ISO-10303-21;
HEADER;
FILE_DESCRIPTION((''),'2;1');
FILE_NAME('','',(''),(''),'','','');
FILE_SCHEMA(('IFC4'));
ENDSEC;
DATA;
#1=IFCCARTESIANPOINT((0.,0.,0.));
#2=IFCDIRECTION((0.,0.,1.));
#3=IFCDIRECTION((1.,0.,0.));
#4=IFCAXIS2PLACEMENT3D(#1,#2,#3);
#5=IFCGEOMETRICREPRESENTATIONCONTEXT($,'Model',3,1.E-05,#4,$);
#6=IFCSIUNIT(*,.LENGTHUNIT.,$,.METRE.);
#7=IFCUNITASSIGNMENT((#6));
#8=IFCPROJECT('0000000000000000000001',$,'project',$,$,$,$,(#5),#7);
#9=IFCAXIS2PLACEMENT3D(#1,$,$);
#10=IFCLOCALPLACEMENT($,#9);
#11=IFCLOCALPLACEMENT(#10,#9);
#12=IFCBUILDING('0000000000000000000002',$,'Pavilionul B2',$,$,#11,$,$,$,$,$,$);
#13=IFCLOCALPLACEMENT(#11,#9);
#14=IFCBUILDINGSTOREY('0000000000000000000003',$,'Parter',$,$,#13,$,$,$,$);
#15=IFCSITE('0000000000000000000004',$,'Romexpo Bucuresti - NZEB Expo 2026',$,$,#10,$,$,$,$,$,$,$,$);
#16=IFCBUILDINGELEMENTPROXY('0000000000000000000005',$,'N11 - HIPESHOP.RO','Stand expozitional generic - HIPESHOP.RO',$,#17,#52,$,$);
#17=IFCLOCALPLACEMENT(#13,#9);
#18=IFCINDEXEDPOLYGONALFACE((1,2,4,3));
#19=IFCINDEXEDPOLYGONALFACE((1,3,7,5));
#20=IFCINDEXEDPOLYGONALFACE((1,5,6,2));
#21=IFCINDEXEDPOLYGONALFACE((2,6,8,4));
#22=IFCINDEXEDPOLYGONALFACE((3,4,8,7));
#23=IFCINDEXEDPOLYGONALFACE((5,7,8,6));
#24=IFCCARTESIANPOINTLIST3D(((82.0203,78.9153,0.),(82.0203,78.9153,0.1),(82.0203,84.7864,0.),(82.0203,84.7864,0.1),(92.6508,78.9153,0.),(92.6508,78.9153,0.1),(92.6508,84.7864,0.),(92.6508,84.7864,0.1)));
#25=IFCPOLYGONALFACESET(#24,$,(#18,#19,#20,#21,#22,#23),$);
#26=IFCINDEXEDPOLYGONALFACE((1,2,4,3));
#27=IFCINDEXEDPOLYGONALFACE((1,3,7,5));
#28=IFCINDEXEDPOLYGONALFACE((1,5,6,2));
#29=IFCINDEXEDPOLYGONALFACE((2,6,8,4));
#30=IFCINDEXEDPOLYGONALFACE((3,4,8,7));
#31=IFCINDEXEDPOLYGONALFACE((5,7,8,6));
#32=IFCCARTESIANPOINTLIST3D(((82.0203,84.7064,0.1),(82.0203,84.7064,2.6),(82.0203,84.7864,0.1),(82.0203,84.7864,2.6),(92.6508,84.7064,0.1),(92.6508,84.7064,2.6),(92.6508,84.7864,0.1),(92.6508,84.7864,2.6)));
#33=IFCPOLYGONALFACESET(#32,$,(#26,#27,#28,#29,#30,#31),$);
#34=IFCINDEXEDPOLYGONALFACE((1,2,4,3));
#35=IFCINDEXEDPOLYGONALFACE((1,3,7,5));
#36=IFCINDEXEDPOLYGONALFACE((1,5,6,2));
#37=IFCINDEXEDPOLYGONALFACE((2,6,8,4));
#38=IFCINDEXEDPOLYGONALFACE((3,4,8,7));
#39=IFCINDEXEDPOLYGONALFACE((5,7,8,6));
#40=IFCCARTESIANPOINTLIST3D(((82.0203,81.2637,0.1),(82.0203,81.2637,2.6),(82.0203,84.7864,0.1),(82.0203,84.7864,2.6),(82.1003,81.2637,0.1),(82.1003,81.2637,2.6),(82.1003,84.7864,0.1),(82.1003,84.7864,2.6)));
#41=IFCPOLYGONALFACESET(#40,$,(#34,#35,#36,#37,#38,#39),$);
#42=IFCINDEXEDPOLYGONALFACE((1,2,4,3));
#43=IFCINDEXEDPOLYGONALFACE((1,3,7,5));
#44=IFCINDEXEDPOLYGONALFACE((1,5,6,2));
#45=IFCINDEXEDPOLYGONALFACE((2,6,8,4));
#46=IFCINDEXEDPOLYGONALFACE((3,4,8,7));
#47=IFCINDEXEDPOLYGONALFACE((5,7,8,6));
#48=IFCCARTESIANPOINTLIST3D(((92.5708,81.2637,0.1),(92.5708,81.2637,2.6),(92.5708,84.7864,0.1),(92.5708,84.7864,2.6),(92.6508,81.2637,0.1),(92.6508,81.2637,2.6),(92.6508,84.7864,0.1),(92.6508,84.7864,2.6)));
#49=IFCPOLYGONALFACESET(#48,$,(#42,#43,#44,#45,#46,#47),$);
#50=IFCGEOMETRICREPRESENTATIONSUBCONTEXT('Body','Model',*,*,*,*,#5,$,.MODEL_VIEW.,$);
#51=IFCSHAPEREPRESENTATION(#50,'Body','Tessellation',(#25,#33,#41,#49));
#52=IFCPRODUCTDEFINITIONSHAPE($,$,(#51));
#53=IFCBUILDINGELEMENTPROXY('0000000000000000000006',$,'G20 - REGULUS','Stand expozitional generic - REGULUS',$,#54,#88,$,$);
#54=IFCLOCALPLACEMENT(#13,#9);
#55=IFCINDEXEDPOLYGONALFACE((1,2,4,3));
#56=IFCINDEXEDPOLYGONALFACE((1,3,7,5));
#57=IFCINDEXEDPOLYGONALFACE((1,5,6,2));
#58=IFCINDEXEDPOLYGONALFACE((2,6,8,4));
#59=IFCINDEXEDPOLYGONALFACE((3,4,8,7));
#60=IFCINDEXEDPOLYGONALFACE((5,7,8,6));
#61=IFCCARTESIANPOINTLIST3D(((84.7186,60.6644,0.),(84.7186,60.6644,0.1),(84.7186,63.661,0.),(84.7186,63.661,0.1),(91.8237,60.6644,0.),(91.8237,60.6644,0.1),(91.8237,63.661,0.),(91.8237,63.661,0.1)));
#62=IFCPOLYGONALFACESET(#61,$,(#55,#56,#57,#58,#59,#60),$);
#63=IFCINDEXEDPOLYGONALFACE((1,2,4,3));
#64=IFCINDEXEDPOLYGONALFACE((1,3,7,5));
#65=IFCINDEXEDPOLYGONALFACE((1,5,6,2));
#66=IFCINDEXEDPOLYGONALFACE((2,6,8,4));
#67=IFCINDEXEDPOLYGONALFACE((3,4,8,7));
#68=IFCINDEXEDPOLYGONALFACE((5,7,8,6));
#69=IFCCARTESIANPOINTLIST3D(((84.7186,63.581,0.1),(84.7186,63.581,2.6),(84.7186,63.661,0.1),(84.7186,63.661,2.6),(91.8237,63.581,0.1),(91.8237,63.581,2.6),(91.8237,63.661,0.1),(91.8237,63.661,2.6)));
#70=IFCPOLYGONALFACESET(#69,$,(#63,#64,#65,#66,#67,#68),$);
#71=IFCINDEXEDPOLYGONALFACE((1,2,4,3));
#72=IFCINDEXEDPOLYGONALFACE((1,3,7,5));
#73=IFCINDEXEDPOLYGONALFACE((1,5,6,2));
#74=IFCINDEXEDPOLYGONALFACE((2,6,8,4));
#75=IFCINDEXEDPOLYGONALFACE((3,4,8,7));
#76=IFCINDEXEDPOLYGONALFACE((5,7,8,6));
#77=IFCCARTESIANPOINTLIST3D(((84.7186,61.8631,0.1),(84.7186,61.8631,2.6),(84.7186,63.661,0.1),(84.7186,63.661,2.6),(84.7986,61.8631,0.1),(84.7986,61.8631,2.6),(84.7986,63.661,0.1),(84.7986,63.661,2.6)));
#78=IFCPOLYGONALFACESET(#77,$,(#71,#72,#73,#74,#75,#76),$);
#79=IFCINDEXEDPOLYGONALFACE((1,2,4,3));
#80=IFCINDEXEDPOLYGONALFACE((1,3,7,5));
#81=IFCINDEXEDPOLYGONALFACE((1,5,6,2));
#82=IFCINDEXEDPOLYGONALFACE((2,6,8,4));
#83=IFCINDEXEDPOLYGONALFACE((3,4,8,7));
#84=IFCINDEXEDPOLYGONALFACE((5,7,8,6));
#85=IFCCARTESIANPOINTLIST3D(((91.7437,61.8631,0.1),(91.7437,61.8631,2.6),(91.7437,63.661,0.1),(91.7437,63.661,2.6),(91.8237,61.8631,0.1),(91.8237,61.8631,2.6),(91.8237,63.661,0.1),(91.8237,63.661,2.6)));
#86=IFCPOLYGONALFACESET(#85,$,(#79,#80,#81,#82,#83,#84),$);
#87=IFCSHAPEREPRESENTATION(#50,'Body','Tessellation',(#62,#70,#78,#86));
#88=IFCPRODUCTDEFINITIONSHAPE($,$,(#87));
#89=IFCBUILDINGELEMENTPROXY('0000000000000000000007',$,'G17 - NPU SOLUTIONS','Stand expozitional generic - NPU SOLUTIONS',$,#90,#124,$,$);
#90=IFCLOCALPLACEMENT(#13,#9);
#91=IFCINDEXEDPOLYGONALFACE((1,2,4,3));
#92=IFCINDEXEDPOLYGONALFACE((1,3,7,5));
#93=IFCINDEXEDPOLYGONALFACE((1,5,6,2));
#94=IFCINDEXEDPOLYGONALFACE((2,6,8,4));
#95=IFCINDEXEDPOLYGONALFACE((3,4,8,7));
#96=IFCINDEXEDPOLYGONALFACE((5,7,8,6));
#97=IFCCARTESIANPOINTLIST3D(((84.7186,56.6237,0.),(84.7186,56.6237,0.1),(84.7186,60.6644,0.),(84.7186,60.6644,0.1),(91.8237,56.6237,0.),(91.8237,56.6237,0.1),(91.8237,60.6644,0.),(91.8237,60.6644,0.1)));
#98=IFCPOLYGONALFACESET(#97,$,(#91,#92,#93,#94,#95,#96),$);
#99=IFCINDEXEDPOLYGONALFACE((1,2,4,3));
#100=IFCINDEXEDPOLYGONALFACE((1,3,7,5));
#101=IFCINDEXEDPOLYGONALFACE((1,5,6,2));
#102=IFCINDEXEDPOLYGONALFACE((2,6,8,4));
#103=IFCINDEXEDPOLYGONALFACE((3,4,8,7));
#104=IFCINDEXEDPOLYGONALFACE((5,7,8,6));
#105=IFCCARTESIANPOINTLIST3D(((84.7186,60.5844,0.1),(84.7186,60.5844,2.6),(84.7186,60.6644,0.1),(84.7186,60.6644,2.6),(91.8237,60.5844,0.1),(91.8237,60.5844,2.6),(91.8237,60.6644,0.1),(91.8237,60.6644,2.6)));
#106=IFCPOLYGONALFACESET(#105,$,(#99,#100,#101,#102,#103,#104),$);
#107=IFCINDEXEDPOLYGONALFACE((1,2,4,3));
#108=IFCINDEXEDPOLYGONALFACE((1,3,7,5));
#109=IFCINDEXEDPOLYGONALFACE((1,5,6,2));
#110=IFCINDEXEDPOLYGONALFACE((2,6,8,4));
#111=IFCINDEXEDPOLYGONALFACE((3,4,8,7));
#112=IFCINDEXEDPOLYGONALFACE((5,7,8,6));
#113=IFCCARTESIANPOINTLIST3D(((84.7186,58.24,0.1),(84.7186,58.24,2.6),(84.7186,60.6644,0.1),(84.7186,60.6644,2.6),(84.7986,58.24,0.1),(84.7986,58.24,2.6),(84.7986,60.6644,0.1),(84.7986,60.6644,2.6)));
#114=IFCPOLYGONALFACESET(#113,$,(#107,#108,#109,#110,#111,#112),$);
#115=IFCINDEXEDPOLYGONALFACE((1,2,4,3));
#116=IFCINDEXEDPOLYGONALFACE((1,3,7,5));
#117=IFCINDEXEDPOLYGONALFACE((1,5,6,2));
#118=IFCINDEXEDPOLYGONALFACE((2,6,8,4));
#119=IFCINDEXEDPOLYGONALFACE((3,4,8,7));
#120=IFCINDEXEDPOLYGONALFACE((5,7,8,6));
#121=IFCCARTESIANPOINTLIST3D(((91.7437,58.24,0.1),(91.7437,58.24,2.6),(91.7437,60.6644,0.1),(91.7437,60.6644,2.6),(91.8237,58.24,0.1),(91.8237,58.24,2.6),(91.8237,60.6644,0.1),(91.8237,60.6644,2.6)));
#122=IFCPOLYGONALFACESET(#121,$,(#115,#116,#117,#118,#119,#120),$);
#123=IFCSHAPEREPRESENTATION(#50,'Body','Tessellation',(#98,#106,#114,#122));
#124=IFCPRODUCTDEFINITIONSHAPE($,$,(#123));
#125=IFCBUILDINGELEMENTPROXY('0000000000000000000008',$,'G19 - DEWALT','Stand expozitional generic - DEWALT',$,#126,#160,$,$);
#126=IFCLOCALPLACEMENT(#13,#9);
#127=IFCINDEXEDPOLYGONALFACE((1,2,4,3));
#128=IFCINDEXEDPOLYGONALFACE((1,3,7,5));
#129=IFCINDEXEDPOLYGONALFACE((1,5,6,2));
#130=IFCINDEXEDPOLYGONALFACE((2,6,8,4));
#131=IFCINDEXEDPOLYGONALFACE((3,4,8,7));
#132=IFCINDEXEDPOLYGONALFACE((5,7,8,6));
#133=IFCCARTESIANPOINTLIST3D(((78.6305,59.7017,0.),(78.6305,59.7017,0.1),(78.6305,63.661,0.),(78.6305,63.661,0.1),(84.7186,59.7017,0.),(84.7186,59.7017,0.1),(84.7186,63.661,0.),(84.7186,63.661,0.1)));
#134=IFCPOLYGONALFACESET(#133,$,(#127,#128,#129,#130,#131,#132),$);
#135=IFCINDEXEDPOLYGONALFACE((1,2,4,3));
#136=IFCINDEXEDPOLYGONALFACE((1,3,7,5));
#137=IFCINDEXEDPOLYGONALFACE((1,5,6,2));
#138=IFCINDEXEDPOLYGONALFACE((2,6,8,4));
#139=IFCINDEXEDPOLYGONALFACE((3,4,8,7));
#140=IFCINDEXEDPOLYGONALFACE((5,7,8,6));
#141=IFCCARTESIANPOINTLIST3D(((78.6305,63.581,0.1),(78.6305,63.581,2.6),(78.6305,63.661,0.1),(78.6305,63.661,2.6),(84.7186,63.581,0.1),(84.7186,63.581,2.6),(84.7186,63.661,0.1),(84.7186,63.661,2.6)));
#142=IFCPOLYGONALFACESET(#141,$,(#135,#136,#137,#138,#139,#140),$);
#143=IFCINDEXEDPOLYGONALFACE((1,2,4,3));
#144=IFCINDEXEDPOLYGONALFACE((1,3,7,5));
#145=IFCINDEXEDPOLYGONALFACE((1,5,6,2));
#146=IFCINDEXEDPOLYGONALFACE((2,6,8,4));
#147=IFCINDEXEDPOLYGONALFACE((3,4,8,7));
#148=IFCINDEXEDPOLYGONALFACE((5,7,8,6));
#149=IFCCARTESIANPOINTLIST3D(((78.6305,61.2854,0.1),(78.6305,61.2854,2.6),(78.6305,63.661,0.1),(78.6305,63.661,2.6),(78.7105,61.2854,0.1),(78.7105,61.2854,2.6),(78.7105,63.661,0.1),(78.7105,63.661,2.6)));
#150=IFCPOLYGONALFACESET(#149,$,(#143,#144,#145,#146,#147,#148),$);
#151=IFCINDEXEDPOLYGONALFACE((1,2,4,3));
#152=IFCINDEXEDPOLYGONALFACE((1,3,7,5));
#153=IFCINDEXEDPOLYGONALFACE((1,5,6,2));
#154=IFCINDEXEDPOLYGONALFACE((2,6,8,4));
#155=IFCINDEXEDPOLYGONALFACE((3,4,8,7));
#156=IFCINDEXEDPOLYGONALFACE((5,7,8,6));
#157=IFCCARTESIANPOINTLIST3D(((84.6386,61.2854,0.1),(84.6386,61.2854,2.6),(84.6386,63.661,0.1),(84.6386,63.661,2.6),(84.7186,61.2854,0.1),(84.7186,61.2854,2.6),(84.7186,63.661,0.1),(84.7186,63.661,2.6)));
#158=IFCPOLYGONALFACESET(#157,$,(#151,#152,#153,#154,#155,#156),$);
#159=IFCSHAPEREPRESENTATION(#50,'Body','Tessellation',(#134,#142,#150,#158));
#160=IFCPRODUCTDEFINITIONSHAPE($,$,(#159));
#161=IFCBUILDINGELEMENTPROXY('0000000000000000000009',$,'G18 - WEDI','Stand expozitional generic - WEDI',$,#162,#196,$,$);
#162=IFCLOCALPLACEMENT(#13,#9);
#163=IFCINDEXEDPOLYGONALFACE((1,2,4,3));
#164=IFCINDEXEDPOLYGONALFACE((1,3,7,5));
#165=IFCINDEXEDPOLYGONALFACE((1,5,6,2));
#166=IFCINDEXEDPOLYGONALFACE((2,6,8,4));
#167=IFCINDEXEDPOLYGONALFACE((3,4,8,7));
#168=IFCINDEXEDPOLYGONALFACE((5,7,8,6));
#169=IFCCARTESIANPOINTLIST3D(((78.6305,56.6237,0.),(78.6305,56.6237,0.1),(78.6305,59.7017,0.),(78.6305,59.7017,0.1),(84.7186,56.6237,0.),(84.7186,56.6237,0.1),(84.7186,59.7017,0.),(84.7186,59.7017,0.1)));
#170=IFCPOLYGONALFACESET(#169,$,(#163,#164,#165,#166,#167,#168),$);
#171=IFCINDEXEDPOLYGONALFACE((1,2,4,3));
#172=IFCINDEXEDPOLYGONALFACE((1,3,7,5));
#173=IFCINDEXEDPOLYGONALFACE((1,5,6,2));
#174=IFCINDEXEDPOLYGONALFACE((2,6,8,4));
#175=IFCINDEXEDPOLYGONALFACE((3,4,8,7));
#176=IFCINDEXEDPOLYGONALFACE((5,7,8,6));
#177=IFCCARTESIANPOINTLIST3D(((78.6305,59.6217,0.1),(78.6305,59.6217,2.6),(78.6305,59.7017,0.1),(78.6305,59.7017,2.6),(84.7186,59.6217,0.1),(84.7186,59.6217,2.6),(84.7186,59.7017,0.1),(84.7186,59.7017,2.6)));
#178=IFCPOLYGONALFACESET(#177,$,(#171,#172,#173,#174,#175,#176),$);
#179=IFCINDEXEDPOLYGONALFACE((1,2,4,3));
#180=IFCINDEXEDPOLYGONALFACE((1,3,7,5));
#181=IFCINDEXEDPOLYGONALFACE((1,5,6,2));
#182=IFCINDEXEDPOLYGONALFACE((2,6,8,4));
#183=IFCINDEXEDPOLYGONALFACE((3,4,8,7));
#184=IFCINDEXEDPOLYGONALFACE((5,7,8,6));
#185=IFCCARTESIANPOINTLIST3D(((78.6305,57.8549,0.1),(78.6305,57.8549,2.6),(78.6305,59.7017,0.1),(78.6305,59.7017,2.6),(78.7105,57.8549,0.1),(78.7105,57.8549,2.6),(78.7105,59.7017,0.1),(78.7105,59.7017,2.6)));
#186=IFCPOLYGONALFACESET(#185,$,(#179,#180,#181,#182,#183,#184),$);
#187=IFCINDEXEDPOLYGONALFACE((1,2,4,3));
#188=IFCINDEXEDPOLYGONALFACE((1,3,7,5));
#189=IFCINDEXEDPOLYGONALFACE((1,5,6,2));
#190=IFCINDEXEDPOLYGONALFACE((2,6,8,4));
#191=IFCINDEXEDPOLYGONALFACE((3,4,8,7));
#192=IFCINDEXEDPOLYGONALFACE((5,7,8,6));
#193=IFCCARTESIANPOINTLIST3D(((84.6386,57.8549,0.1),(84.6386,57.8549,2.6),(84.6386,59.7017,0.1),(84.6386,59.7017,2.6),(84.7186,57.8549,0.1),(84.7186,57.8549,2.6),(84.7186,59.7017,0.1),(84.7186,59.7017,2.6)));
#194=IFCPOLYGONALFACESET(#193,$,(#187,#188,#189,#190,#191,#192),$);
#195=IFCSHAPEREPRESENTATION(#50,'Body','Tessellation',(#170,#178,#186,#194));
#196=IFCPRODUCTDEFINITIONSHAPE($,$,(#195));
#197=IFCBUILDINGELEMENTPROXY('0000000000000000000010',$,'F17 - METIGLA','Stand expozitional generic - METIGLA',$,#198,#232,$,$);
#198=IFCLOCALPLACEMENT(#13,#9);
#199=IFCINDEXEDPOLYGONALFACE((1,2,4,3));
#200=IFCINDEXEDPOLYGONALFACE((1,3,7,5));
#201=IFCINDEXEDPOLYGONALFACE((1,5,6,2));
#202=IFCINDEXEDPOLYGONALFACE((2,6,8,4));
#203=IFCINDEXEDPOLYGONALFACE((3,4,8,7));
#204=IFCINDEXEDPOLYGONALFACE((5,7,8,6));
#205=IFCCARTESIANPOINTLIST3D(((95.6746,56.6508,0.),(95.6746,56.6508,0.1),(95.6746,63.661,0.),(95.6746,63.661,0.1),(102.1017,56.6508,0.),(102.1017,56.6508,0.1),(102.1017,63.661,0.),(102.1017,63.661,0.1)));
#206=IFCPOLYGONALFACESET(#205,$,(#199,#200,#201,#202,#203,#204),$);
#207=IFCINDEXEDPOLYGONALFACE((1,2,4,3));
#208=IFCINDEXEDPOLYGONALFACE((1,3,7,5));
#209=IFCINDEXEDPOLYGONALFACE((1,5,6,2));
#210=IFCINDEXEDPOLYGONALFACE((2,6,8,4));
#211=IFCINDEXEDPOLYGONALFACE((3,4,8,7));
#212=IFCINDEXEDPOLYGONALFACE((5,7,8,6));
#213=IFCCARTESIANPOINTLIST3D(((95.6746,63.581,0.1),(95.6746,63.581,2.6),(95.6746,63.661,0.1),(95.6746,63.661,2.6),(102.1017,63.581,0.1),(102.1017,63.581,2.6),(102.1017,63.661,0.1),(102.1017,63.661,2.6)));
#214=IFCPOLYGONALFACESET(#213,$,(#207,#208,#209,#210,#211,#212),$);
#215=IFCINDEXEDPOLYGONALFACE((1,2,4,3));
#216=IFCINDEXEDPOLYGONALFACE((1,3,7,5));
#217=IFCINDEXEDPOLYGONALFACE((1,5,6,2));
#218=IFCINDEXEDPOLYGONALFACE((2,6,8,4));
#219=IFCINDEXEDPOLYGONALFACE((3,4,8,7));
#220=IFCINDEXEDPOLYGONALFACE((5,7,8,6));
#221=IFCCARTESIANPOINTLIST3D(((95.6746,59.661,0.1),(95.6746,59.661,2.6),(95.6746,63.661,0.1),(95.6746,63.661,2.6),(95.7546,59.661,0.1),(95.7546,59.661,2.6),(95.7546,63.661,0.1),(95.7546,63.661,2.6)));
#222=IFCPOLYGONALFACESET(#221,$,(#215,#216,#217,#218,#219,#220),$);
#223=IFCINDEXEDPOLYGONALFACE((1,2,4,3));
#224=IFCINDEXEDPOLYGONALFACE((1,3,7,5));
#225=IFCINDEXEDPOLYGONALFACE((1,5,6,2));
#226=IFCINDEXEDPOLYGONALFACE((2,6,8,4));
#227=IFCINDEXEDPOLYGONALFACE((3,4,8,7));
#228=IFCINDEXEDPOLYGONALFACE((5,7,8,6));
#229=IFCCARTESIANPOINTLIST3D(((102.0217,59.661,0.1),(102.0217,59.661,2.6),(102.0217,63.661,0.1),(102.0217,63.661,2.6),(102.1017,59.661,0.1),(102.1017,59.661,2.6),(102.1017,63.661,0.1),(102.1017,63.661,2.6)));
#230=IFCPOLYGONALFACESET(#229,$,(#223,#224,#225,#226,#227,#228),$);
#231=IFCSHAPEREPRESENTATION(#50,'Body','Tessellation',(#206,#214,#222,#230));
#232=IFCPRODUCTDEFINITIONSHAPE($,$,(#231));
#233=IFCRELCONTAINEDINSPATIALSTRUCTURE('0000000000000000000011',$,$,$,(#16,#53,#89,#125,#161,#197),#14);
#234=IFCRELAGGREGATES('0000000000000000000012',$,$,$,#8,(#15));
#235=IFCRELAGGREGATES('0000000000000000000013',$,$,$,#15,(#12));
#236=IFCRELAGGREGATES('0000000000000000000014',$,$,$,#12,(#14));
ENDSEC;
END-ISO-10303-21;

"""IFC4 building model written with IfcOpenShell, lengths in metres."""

from ifc_helpers import new_model, si_unit, frame, frame_2d, origin, origin_with_axes, place, context, subcontext, project, spatial, rectangle, extrude, element, save


model = new_model("IFC4")

# Units and contexts
model_context = context("Model", 3, precision=1e-05, world=origin_with_axes())
body_context = subcontext(model_context, "Body", "Model", "MODEL_VIEW")
ifc_project = project(units=[si_unit("LENGTHUNIT", "METRE")], contexts=[model_context])

# Site, building, storey
site_placement = place(None, origin())
site = spatial("IfcSite", under=ifc_project, at=site_placement, Name="Romexpo Bucuresti - NZEB Expo 2026")
building_placement = place(site_placement, origin())
building = spatial("IfcBuilding", under=site, at=building_placement, Name="Pavilionul B2")
storey_placement = place(building_placement, origin())
storey = spatial("IfcBuildingStorey", under=building, at=storey_placement, Name="Parter")

# Building element proxies
proxy_1_placement = place(storey_placement, frame((82.0203, 78.9153, 0.0), z_axis=(0.0, 0.0, 1.0), x_axis=(1.0, 0.0, 0.0)))
element("IfcBuildingElementProxy", 1, at=proxy_1_placement, inside=storey, Name="N11 - HIPESHOP.RO", Description="Stand expozitional generic - HIPESHOP.RO", context=body_context, shape_type="SweptSolid", body=[
    extrude(rectangle(XDim=10.6305, YDim=5.8712, at=frame_2d((5.3153, 2.9356))), origin(), (0.0, 0.0, 1.0), 0.1),
    extrude(rectangle(XDim=10.6305, YDim=0.08, at=frame_2d((5.3153, 5.8312))), frame((0.0, 0.0, 0.1)), (0.0, 0.0, 1.0), 2.5),
    extrude(rectangle(XDim=0.08, YDim=3.5227, at=frame_2d((0.04, 4.1098))), frame((0.0, 0.0, 0.1)), (0.0, 0.0, 1.0), 2.5),
    extrude(rectangle(XDim=0.08, YDim=3.5227, at=frame_2d((10.5905, 4.1098))), frame((0.0, 0.0, 0.1)), (0.0, 0.0, 1.0), 2.5),
])
proxy_2_placement = place(storey_placement, frame((84.7186, 60.6644, 0.0), z_axis=(0.0, 0.0, 1.0), x_axis=(1.0, 0.0, 0.0)))
element("IfcBuildingElementProxy", 2, at=proxy_2_placement, inside=storey, Name="G20 - REGULUS", Description="Stand expozitional generic - REGULUS", context=body_context, shape_type="SweptSolid", body=[
    extrude(rectangle(XDim=7.1051, YDim=2.9966, at=frame_2d((3.5525, 1.4983))), origin(), (0.0, 0.0, 1.0), 0.1),
    extrude(rectangle(XDim=7.1051, YDim=0.08, at=frame_2d((3.5525, 2.9566))), frame((0.0, 0.0, 0.1)), (0.0, 0.0, 1.0), 2.5),
    extrude(rectangle(XDim=0.08, YDim=1.798, at=frame_2d((0.04, 2.0976))), frame((0.0, 0.0, 0.1)), (0.0, 0.0, 1.0), 2.5),
    extrude(rectangle(XDim=0.08, YDim=1.798, at=frame_2d((7.0651, 2.0976))), frame((0.0, 0.0, 0.1)), (0.0, 0.0, 1.0), 2.5),
])
proxy_3_placement = place(storey_placement, frame((84.7186, 56.6237, 0.0), z_axis=(0.0, 0.0, 1.0), x_axis=(1.0, 0.0, 0.0)))
element("IfcBuildingElementProxy", 3, at=proxy_3_placement, inside=storey, Name="G17 - NPU SOLUTIONS", Description="Stand expozitional generic - NPU SOLUTIONS", context=body_context, shape_type="SweptSolid", body=[
    extrude(rectangle(XDim=7.1051, YDim=4.0407, at=frame_2d((3.5525, 2.0203))), origin(), (0.0, 0.0, 1.0), 0.1),
    extrude(rectangle(XDim=7.1051, YDim=0.08, at=frame_2d((3.5525, 4.0007))), frame((0.0, 0.0, 0.1)), (0.0, 0.0, 1.0), 2.5),
    extrude(rectangle(XDim=0.08, YDim=2.4244, at=frame_2d((0.04, 2.8285))), frame((0.0, 0.0, 0.1)), (0.0, 0.0, 1.0), 2.5),
    extrude(rectangle(XDim=0.08, YDim=2.4244, at=frame_2d((7.0651, 2.8285))), frame((0.0, 0.0, 0.1)), (0.0, 0.0, 1.0), 2.5),
])
proxy_4_placement = place(storey_placement, frame((78.6305, 59.7017, 0.0), z_axis=(0.0, 0.0, 1.0), x_axis=(1.0, 0.0, 0.0)))
element("IfcBuildingElementProxy", 4, at=proxy_4_placement, inside=storey, Name="G19 - DEWALT", Description="Stand expozitional generic - DEWALT", context=body_context, shape_type="SweptSolid", body=[
    extrude(rectangle(XDim=6.0881, YDim=3.9593, at=frame_2d((3.0441, 1.9797))), origin(), (0.0, 0.0, 1.0), 0.1),
    extrude(rectangle(XDim=6.0881, YDim=0.08, at=frame_2d((3.0441, 3.9193))), frame((0.0, 0.0, 0.1)), (0.0, 0.0, 1.0), 2.5),
    extrude(rectangle(XDim=0.08, YDim=2.3756, at=frame_2d((0.04, 2.7715))), frame((0.0, 0.0, 0.1)), (0.0, 0.0, 1.0), 2.5),
    extrude(rectangle(XDim=0.08, YDim=2.3756, at=frame_2d((6.0481, 2.7715))), frame((0.0, 0.0, 0.1)), (0.0, 0.0, 1.0), 2.5),
])
proxy_5_placement = place(storey_placement, frame((78.6305, 56.6237, 0.0), z_axis=(0.0, 0.0, 1.0), x_axis=(1.0, 0.0, 0.0)))
element("IfcBuildingElementProxy", 5, at=proxy_5_placement, inside=storey, Name="G18 - WEDI", Description="Stand expozitional generic - WEDI", context=body_context, shape_type="SweptSolid", body=[
    extrude(rectangle(XDim=6.0881, YDim=3.078, at=frame_2d((3.0441, 1.539))), origin(), (0.0, 0.0, 1.0), 0.1),
    extrude(rectangle(XDim=6.0881, YDim=0.08, at=frame_2d((3.0441, 3.038))), frame((0.0, 0.0, 0.1)), (0.0, 0.0, 1.0), 2.5),
    extrude(rectangle(XDim=0.08, YDim=1.8468, at=frame_2d((0.04, 2.1546))), frame((0.0, 0.0, 0.1)), (0.0, 0.0, 1.0), 2.5),
    extrude(rectangle(XDim=0.08, YDim=1.8468, at=frame_2d((6.0481, 2.1546))), frame((0.0, 0.0, 0.1)), (0.0, 0.0, 1.0), 2.5),
])
proxy_6_placement = place(storey_placement, frame((95.6746, 56.6508, 0.0), z_axis=(0.0, 0.0, 1.0), x_axis=(1.0, 0.0, 0.0)))
element("IfcBuildingElementProxy", 6, at=proxy_6_placement, inside=storey, Name="F17 - METIGLA", Description="Stand expozitional generic - METIGLA", context=body_context, shape_type="SweptSolid", body=[
    extrude(rectangle(XDim=6.4271, YDim=7.0102, at=frame_2d((3.2136, 3.5051))), origin(), (0.0, 0.0, 1.0), 0.1),
    extrude(rectangle(XDim=6.4271, YDim=0.08, at=frame_2d((3.2136, 6.9702))), frame((0.0, 0.0, 0.1)), (0.0, 0.0, 1.0), 2.5),
    extrude(rectangle(XDim=0.08, YDim=4.0, at=frame_2d((0.04, 5.0102))), frame((0.0, 0.0, 0.1)), (0.0, 0.0, 1.0), 2.5),
    extrude(rectangle(XDim=0.08, YDim=4.0, at=frame_2d((6.3871, 5.0102))), frame((0.0, 0.0, 0.1)), (0.0, 0.0, 1.0), 2.5),
])

save(model, "model.ifc")
